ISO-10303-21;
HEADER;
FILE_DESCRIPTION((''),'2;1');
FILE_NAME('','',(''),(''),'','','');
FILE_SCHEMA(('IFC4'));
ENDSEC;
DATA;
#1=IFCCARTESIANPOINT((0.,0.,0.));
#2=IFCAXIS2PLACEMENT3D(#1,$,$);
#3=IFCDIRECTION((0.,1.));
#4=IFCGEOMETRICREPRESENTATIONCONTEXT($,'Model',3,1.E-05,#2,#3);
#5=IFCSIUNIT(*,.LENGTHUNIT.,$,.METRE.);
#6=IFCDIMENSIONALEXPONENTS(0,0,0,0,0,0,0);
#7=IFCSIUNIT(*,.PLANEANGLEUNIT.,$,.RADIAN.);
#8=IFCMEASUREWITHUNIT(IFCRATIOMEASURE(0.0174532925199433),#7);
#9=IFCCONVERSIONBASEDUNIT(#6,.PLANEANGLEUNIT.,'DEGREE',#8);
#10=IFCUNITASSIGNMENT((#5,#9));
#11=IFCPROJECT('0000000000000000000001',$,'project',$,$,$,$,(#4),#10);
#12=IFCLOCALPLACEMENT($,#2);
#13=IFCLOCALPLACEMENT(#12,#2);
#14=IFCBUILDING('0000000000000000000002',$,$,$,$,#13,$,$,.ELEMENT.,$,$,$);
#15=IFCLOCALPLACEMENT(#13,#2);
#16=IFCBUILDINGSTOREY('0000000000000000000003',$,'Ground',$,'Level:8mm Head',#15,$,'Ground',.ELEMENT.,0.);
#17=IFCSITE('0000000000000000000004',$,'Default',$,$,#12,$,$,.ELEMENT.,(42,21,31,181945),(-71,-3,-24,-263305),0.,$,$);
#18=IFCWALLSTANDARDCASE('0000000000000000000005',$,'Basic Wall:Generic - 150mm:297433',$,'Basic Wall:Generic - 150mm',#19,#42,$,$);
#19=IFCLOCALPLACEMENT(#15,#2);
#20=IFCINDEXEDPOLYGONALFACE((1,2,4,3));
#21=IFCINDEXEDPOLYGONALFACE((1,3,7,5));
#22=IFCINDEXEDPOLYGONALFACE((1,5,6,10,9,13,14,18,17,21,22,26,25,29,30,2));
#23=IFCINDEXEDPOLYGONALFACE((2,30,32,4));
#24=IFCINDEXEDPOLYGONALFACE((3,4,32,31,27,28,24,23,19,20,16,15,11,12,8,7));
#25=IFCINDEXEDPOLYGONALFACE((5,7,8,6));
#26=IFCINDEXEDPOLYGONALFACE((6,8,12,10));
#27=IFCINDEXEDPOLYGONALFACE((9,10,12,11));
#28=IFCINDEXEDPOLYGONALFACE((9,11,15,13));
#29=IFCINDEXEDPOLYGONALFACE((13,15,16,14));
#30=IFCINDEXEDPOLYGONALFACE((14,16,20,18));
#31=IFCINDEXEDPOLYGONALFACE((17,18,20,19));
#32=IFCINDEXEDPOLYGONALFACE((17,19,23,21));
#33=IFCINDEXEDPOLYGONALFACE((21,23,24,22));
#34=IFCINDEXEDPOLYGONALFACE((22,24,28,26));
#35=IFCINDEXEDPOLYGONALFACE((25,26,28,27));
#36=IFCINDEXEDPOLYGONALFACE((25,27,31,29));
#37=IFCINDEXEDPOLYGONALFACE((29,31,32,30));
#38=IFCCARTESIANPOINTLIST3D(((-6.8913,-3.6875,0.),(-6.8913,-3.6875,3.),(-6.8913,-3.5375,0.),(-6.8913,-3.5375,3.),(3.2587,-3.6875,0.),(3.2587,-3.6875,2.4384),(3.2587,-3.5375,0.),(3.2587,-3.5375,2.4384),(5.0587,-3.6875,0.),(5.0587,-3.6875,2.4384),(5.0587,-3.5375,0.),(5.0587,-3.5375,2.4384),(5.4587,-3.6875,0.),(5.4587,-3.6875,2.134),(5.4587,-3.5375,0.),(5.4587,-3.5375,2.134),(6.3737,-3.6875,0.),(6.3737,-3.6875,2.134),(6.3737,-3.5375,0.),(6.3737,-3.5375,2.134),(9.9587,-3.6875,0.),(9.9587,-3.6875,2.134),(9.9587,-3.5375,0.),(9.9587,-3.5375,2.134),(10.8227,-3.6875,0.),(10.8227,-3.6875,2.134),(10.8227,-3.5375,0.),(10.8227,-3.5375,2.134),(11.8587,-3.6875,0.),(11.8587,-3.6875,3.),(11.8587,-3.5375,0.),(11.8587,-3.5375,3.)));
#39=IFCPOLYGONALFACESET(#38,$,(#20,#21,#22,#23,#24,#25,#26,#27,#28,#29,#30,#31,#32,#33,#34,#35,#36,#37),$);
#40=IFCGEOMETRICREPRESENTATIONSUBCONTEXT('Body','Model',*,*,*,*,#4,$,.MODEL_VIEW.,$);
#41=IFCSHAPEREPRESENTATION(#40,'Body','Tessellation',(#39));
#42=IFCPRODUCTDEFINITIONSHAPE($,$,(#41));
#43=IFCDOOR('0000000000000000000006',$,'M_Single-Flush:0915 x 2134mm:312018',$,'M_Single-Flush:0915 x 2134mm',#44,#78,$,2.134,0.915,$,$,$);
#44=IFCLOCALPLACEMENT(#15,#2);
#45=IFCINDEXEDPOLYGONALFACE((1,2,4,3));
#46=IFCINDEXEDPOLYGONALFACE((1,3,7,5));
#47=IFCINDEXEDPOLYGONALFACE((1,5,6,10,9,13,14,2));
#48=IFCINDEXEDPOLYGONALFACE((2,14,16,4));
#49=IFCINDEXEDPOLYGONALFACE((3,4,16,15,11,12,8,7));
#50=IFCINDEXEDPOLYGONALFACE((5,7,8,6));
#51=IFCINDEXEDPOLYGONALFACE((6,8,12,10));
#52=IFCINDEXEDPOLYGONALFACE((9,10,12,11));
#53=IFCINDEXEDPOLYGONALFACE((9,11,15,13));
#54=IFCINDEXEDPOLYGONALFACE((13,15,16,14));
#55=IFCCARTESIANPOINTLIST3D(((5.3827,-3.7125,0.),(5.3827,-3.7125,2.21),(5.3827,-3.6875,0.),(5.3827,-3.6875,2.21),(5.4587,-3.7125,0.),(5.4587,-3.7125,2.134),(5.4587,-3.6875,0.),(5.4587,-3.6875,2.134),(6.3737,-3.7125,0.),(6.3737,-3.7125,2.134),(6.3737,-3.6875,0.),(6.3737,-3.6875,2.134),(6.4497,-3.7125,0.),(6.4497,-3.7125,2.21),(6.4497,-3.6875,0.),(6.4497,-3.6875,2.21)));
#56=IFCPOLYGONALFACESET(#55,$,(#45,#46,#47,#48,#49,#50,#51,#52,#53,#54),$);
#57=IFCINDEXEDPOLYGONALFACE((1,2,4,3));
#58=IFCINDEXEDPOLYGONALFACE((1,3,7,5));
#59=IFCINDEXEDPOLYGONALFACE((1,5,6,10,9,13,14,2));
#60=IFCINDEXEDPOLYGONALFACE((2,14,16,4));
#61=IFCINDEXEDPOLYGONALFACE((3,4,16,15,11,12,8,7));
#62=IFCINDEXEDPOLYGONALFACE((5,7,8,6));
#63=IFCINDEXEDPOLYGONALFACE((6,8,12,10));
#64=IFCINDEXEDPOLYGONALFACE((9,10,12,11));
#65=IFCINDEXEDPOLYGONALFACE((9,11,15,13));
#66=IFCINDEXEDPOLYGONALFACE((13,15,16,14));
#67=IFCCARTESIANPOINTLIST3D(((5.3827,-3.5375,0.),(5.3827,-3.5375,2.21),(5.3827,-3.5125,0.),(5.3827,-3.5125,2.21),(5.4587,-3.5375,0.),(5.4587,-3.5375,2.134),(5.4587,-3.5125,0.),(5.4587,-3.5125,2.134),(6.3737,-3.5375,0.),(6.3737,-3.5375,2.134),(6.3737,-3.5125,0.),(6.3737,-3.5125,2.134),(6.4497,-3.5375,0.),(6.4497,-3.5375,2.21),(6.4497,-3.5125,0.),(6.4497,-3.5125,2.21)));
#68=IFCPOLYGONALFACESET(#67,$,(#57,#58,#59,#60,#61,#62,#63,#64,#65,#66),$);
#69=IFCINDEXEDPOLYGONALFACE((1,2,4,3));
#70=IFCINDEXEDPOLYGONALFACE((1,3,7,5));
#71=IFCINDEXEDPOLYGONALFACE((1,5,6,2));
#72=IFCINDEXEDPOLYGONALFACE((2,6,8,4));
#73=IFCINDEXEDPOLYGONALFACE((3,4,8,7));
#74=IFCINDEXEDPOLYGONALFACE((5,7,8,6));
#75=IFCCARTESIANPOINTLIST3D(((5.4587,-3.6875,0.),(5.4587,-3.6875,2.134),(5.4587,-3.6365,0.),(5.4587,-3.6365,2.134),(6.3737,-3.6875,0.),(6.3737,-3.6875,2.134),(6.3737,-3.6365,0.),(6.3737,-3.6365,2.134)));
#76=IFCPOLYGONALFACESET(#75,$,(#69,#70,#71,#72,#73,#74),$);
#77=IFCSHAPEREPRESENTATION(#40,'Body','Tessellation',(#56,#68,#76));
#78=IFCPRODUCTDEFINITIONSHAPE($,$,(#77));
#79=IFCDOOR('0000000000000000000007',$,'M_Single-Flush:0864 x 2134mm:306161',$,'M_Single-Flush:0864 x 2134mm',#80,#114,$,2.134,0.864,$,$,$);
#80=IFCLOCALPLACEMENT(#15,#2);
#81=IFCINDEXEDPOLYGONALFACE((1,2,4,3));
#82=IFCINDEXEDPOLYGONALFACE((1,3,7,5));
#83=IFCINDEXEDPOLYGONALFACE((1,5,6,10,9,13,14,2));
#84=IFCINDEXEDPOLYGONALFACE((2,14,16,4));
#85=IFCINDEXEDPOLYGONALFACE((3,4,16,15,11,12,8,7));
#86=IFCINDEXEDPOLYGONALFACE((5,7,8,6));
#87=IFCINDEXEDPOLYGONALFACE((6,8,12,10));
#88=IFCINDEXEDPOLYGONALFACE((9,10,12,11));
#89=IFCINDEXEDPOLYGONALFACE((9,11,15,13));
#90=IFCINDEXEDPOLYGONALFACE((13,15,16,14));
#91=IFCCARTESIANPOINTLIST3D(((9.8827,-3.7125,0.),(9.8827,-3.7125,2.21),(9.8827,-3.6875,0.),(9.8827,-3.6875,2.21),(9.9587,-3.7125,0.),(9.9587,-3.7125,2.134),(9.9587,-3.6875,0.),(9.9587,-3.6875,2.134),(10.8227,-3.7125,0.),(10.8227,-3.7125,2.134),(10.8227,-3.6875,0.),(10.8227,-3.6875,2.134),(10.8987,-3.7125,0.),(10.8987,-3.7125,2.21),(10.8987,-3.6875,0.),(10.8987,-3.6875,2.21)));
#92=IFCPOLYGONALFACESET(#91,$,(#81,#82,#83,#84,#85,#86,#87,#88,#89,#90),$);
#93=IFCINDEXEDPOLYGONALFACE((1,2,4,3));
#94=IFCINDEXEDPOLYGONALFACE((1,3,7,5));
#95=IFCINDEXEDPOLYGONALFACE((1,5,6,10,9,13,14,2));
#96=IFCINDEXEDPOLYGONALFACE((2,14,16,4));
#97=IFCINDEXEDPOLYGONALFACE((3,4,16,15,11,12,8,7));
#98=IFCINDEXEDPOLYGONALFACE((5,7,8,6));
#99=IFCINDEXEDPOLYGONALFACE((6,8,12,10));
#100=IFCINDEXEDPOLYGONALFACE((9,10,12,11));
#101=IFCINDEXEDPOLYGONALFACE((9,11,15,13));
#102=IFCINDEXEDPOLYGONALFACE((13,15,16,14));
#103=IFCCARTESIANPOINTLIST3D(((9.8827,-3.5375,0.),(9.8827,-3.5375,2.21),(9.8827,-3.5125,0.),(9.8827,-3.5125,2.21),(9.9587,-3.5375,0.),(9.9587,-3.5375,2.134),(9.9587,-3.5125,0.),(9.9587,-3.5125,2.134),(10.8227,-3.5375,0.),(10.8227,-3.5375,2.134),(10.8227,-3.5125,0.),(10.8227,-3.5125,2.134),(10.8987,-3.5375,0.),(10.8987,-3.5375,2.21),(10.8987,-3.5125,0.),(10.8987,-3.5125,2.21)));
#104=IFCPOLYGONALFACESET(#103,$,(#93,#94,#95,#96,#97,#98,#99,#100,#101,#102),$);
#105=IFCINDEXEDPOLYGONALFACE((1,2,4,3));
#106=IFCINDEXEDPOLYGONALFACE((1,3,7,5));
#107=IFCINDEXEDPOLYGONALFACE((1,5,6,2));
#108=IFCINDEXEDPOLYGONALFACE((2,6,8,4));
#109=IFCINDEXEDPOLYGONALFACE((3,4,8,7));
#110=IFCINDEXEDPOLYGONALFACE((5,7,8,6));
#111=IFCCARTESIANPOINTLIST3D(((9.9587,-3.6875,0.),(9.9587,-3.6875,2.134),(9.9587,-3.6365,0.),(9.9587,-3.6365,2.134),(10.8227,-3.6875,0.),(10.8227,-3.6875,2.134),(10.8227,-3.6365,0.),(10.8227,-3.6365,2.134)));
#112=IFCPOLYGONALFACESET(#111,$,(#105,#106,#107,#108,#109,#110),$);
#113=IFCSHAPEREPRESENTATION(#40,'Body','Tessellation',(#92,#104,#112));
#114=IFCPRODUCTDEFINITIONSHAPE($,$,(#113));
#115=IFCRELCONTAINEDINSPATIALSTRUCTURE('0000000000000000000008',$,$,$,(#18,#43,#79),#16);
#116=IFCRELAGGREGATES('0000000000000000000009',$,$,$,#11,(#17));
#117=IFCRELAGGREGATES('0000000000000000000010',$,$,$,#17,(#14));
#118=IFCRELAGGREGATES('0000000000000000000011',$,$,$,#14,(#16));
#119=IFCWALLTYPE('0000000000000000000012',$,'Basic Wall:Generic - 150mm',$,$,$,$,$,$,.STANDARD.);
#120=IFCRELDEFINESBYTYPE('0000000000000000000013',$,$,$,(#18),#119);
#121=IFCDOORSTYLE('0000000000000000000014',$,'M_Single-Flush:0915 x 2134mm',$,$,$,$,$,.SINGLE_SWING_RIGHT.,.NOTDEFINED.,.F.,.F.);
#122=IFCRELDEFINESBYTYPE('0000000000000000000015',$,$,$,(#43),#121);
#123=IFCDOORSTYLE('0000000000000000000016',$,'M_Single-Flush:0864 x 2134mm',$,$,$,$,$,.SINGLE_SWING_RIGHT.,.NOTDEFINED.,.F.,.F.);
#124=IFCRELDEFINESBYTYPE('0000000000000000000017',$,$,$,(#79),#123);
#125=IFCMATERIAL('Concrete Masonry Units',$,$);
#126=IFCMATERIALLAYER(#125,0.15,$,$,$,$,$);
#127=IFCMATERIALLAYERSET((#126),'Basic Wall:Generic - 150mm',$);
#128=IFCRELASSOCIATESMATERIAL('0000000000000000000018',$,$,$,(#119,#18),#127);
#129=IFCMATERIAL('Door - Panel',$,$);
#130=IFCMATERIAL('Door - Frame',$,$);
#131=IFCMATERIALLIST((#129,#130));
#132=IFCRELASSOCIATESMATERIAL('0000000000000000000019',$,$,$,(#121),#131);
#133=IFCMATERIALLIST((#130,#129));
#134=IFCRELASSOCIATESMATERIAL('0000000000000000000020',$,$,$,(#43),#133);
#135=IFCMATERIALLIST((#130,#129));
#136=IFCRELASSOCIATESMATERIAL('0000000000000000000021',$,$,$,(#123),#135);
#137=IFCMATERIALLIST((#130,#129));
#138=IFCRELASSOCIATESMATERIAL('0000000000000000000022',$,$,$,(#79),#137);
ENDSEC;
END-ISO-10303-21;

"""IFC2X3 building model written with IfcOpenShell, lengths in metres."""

from ifc_helpers import new_model, entity, si_unit, converted_unit, direction, frame, frame_2d, origin, origin_2d_with_axis, place, context, subcontext, project, spatial, polyline, rectangle, outline, extrude, source, transform, mapped, material, material_list, layer, layer_set, layer_usage, type_object, type_shapes, element, fill, save


model = new_model("IFC2X3")

# Units and contexts
model_context = context("Model", 3, precision=1e-05, world=origin(), true_north=direction((0.0, 1.0)))
body_context = subcontext(model_context, "Body", "Model", "MODEL_VIEW")
ifc_project = project(units=[si_unit("LENGTHUNIT", "METRE"), converted_unit("PLANEANGLEUNIT", "DEGREE", entity("IfcRatioMeasure", 0.0174532925199433), si_unit("PLANEANGLEUNIT", "RADIAN"), dimensions=[0, 0, 0, 0, 0, 0, 0])], contexts=[model_context])

# Site, building, storey
site_placement = place(None, origin())
site = spatial("IfcSite", under=ifc_project, at=site_placement, Name="Default", CompositionType="ELEMENT", RefLatitude=(42, 21, 31, 181945), RefLongitude=(-71, -3, -24, -263305), RefElevation=0.0)
building_placement = place(site_placement, origin())
building = spatial("IfcBuilding", under=site, at=building_placement, CompositionType="ELEMENT")
storey_placement = place(building_placement, origin())
storey = spatial("IfcBuildingStorey", under=building, at=storey_placement, Name="Ground", ObjectType="Level:8mm Head", LongName="Ground", CompositionType="ELEMENT", Elevation=0.0)

# Wall, openings, doors
ifc_material_1 = material(Name="Concrete Masonry Units")
ifc_layer = layer(ifc_material_1, 0.15)
ifc_layer_set = layer_set([ifc_layer], Name="Basic Wall:Generic - 150mm")
ifc_layer_usage_1 = layer_usage(ifc_layer_set, "AXIS2", "NEGATIVE", 0.075)
wall_type = type_object("IfcWallType", Name="Basic Wall:Generic - 150mm", PredefinedType="STANDARD", material=ifc_layer_set)
wall_1_placement = place(storey_placement, frame((11.8587, -3.6125, 0.0), z_axis=(0.0, 0.0, 1.0), x_axis=(-1.0, 0.0, 0.0)))
wall_1 = element("IfcWallStandardCase", 1, at=wall_1_placement, inside=storey, type_object=wall_type, material=ifc_layer_usage_1, Name="Basic Wall:Generic - 150mm:297433", ObjectType="Basic Wall:Generic - 150mm", context=body_context, shape_type="SweptSolid", body=[
    extrude(rectangle(XDim=18.75, YDim=0.15, at=frame_2d((9.375, 0.0), x_axis=(-1.0, 0.0))), origin(), (0.0, 0.0, 1.0), 3.0),
])
opening_1_placement = place(wall_1_placement, origin())
element("IfcOpeningElement", 2, at=opening_1_placement, cuts=wall_1, ObjectType="Opening", context=body_context, shape_type="SweptSolid", body=[
    extrude(rectangle(XDim=2.4384, YDim=1.8, at=origin_2d_with_axis()), frame((7.7, -0.075, 1.2192), z_axis=(0.0, 1.0, 0.0), x_axis=(0.0, 0.0, -1.0)), (0.0, 0.0, 1.0), 0.15),
])
opening_2_placement = place(wall_1_placement, frame((1.036, -0.075, 0.0)))
opening_2 = element("IfcOpeningElement", 3, at=opening_2_placement, cuts=wall_1, ObjectType="Opening", context=body_context, shape_type="SweptSolid", body=[
    extrude(rectangle(XDim=0.864, YDim=2.134, at=frame_2d((1.067, 0.432), x_axis=(0.0, 1.0))), frame((0.0, 0.0, 0.0), z_axis=(0.0, 1.0, 0.0), x_axis=(0.0, 0.0, 1.0)), (0.0, 0.0, 1.0), 0.15),
])
opening_3_placement = place(wall_1_placement, frame((5.485, -0.075, 0.0)))
opening_3 = element("IfcOpeningElement", 4, at=opening_3_placement, cuts=wall_1, ObjectType="Opening", context=body_context, shape_type="SweptSolid", body=[
    extrude(rectangle(XDim=0.915, YDim=2.134, at=frame_2d((1.067, 0.4575), x_axis=(0.0, 1.0))), frame((0.0, 0.0, 0.0), z_axis=(0.0, 1.0, 0.0), x_axis=(0.0, 0.0, 1.0)), (0.0, 0.0, 1.0), 0.15),
])
ifc_material_2 = material(Name="Door - Frame")
ifc_material_3 = material(Name="Door - Panel")
ifc_material_list_1 = material_list([ifc_material_2, ifc_material_3])
ifc_material_list_2 = material_list([ifc_material_3, ifc_material_2])
door_style_1 = type_object("IfcDoorStyle", Name="M_Single-Flush:0915 x 2134mm", ConstructionType="NOTDEFINED", OperationType="SINGLE_SWING_RIGHT", ParameterTakesPrecedence=False, Sizeable=False, material=ifc_material_list_2)
shared_shape_1 = source(origin(), body_context, "Body", "SweptSolid", [
    extrude(outline(polyline([(-0.5335, -1.124), (0.5335, -1.124), (0.5335, 1.086), (0.4575, 1.086), (0.4575, -1.048), (-0.4575, -1.048), (-0.4575, 1.086), (-0.5335, 1.086), (-0.5335, -1.124)])), frame((0.4575, 0.15, 1.086), z_axis=(0.0, 1.0, 0.0), x_axis=(1.0, 0.0, 0.0)), (0.0, 0.0, 1.0), 0.025),
    extrude(outline(polyline([(-1.124, -0.5335), (1.086, -0.5335), (1.086, -0.4575), (-1.048, -0.4575), (-1.048, 0.4575), (1.086, 0.4575), (1.086, 0.5335), (-1.124, 0.5335), (-1.124, -0.5335)])), frame((0.4575, -0.025, 1.086), z_axis=(0.0, 1.0, 0.0), x_axis=(0.0, 0.0, -1.0)), (0.0, 0.0, 1.0), 0.025),
    extrude(rectangle(XDim=0.051, YDim=0.915, at=frame_2d((0.0, 0.0), x_axis=(1.0, 0.0))), frame((0.4575, 0.1245, 0.0), z_axis=(0.0, 0.0, 1.0), x_axis=(0.0, 1.0, 0.0)), (0.0, 0.0, 1.0), 2.134),
])
type_shapes(door_style_1, [shared_shape_1])
door_1_placement = place(opening_3_placement, origin())
door_1 = element("IfcDoor", 5, at=door_1_placement, inside=storey, type_object=door_style_1, material=ifc_material_list_1, Name="M_Single-Flush:0915 x 2134mm:312018", ObjectType="M_Single-Flush:0915 x 2134mm", OverallHeight=2.134, OverallWidth=0.915, context=body_context, shape_type="MappedRepresentation", body=[
    mapped(shared_shape_1, transform((0.0, 0.0, 0.0), scale=1.0)),
])
fill(opening_3, door_1)
ifc_material_list_3 = material_list([ifc_material_2, ifc_material_3])
ifc_material_list_4 = material_list([ifc_material_2, ifc_material_3])
door_style_2 = type_object("IfcDoorStyle", Name="M_Single-Flush:0864 x 2134mm", ConstructionType="NOTDEFINED", OperationType="SINGLE_SWING_RIGHT", ParameterTakesPrecedence=False, Sizeable=False, material=ifc_material_list_4)
shared_shape_2 = source(origin(), body_context, "Body", "SweptSolid", [
    extrude(outline(polyline([(-0.508, -1.124), (0.508, -1.124), (0.508, 1.086), (0.432, 1.086), (0.432, -1.048), (-0.432, -1.048), (-0.432, 1.086), (-0.508, 1.086), (-0.508, -1.124)])), frame((0.432, 0.15, 1.086), z_axis=(0.0, 1.0, 0.0), x_axis=(1.0, 0.0, 0.0)), (0.0, 0.0, 1.0), 0.025),
    extrude(outline(polyline([(-1.124, -0.508), (1.086, -0.508), (1.086, -0.432), (-1.048, -0.432), (-1.048, 0.432), (1.086, 0.432), (1.086, 0.508), (-1.124, 0.508), (-1.124, -0.508)])), frame((0.432, -0.025, 1.086), z_axis=(0.0, 1.0, 0.0), x_axis=(0.0, 0.0, -1.0)), (0.0, 0.0, 1.0), 0.025),
    extrude(rectangle(XDim=0.051, YDim=0.864, at=frame_2d((0.0, 0.0), x_axis=(1.0, 0.0))), frame((0.432, 0.1245, 0.0), z_axis=(0.0, 0.0, 1.0), x_axis=(0.0, 1.0, 0.0)), (0.0, 0.0, 1.0), 2.134),
])
type_shapes(door_style_2, [shared_shape_2])
door_2_placement = place(opening_2_placement, origin())
door_2 = element("IfcDoor", 6, at=door_2_placement, inside=storey, type_object=door_style_2, material=ifc_material_list_3, Name="M_Single-Flush:0864 x 2134mm:306161", ObjectType="M_Single-Flush:0864 x 2134mm", OverallHeight=2.134, OverallWidth=0.864, context=body_context, shape_type="MappedRepresentation", body=[
    mapped(shared_shape_2, transform((0.0, 0.0, 0.0), scale=1.0)),
])
fill(opening_2, door_2)

save(model, "model.ifc")
